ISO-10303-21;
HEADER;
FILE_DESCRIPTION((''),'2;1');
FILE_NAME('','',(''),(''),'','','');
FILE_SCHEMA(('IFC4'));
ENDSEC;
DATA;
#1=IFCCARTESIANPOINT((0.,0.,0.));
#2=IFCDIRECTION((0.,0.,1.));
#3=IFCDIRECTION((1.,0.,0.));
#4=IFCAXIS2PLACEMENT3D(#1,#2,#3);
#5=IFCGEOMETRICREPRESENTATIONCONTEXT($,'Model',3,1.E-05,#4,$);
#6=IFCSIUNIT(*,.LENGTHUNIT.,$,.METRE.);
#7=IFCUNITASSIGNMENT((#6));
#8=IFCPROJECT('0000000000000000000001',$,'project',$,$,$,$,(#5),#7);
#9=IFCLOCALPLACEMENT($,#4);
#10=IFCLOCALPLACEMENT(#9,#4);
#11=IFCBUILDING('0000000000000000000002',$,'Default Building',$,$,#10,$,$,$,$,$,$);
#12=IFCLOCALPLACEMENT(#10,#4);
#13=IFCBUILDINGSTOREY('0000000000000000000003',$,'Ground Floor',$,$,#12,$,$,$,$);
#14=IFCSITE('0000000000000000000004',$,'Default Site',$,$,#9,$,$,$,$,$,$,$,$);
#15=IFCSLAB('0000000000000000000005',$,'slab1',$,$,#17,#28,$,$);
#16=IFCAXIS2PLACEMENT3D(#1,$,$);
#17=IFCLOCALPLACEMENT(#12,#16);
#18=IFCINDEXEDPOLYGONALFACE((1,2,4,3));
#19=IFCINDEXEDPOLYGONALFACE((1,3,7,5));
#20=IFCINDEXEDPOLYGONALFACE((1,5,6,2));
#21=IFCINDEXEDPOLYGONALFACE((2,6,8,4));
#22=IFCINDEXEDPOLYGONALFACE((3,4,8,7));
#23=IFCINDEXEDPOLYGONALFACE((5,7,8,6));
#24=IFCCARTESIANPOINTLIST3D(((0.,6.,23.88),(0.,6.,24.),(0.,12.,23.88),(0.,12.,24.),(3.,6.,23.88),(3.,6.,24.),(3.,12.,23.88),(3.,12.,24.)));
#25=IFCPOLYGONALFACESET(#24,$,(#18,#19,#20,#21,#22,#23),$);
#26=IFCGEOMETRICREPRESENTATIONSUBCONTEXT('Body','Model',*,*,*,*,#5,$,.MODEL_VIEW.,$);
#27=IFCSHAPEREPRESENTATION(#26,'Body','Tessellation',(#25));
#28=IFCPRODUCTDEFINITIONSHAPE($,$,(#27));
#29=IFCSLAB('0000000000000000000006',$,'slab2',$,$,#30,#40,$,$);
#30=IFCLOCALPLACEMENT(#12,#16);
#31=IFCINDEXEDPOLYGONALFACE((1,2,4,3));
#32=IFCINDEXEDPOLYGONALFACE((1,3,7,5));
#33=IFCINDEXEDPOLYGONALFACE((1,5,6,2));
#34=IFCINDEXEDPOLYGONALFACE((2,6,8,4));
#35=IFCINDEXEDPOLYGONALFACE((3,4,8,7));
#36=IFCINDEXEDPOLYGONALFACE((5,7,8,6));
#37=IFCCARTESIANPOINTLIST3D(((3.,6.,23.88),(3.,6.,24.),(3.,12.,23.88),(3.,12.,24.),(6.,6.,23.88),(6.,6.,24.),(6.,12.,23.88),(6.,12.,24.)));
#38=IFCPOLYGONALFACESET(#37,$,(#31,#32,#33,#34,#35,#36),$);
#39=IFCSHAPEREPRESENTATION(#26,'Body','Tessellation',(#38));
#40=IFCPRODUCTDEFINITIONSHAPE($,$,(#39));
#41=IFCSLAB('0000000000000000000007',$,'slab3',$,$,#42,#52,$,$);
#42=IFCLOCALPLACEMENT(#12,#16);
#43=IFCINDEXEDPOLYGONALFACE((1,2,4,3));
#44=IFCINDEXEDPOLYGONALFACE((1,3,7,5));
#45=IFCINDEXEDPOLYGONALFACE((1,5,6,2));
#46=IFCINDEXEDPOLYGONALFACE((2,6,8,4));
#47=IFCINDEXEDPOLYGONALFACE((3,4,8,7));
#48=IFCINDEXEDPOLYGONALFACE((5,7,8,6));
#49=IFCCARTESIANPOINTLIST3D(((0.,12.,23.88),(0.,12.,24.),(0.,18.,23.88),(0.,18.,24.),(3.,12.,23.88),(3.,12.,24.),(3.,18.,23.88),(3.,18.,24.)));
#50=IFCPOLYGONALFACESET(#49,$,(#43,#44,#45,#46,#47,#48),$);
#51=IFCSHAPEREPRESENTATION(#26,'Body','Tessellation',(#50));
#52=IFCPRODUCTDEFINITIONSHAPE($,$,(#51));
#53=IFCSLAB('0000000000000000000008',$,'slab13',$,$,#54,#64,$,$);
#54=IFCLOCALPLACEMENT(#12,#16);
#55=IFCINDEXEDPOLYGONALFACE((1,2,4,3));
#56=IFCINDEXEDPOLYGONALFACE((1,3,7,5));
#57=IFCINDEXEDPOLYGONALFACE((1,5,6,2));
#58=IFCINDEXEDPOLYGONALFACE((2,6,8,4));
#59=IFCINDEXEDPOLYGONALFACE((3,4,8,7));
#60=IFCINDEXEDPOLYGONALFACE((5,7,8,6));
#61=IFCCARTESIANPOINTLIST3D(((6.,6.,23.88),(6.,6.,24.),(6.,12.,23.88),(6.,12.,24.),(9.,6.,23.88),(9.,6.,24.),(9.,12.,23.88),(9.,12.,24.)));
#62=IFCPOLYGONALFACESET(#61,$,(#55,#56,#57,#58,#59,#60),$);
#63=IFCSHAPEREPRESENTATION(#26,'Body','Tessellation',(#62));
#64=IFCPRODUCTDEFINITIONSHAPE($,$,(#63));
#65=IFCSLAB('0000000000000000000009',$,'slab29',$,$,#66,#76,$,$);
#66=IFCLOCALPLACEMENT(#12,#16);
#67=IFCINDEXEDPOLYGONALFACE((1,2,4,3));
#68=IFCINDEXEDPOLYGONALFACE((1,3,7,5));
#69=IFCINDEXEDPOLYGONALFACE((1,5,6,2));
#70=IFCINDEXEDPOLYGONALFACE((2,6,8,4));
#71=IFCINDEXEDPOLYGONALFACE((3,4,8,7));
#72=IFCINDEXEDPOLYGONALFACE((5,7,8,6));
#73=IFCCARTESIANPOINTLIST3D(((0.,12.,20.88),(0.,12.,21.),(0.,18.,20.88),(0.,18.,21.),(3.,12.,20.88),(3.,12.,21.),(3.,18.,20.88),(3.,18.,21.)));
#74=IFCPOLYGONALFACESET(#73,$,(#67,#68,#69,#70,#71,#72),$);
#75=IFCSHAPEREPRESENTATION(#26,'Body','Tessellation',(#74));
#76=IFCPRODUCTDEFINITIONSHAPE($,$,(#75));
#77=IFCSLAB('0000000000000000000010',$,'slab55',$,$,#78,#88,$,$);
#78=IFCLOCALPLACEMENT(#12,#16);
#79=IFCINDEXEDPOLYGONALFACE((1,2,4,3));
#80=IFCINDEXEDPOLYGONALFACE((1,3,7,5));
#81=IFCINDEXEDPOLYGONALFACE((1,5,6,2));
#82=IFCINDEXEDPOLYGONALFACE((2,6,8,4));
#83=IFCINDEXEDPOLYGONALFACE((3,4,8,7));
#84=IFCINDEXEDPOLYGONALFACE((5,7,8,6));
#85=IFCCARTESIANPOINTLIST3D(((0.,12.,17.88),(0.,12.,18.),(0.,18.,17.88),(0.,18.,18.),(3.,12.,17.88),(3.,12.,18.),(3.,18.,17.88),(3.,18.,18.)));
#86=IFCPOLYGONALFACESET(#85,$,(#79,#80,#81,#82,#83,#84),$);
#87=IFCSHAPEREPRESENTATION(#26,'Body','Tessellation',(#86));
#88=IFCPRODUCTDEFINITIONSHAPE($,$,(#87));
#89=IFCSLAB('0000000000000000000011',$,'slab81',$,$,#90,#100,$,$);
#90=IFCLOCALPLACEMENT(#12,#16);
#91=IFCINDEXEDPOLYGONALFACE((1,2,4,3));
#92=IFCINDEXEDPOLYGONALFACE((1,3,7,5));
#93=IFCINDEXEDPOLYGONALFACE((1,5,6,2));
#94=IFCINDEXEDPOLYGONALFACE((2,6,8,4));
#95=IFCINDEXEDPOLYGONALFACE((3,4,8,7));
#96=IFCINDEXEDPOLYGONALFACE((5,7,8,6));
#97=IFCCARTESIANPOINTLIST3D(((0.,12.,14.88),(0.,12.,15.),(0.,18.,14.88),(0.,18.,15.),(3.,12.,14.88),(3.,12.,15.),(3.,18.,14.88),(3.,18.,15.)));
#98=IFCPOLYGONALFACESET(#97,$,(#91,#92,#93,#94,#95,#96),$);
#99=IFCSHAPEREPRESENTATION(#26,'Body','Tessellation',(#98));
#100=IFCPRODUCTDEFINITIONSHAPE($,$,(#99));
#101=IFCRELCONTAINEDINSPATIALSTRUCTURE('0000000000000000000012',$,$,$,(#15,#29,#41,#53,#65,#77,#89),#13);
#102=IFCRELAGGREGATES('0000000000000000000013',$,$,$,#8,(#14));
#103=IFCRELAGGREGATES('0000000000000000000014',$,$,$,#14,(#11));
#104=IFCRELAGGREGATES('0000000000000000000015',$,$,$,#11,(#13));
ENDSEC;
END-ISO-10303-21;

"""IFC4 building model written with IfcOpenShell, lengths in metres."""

from ifc_helpers import new_model, si_unit, frame, origin_with_axes, place, context, subcontext, project, spatial, indexed_curve, outline, extrude, element, save


model = new_model("IFC4")

# Units and contexts
model_context = context("Model", 3, precision=1e-05, world=origin_with_axes())
body_context = subcontext(model_context, "Body", "Model", "MODEL_VIEW")
ifc_project = project(units=[si_unit("LENGTHUNIT", "METRE")], contexts=[model_context])

# Site, building, storey
site_placement = place(None, origin_with_axes())
site = spatial("IfcSite", under=ifc_project, at=site_placement, Name="Default Site")
building_placement = place(site_placement, origin_with_axes())
building = spatial("IfcBuilding", under=site, at=building_placement, Name="Default Building")
storey_placement = place(building_placement, origin_with_axes())
storey = spatial("IfcBuildingStorey", under=building, at=storey_placement, Name="Ground Floor")

# Slabs
for number, where, z_axis, x_axis, name in (
    (1, (0.0, 6.0, 23.88), (0.0, 0.0, 1.0), (1.0, 0.0, 0.0), "slab1"),
    (2, (3.0, 6.0, 23.88), (0.0, 0.0, 1.0), (1.0, 0.0, 0.0), "slab2"),
    (3, (0.0, 12.0, 23.88), (0.0, 0.0, 1.0), (1.0, 0.0, 0.0), "slab3"),
    (4, (6.0, 6.0, 23.88), (0.0, 0.0, 1.0), (1.0, 0.0, 0.0), "slab13"),
    (5, (0.0, 12.0, 20.88), (0.0, 0.0, 1.0), (1.0, 0.0, 0.0), "slab29"),
    (6, (0.0, 12.0, 17.88), (0.0, 0.0, 1.0), (1.0, 0.0, 0.0), "slab55"),
    (7, (0.0, 12.0, 14.88), (0.0, 0.0, 1.0), (1.0, 0.0, 0.0), "slab81"),
):
    element("IfcSlab", number, at=place(storey_placement, frame(where, z_axis=z_axis, x_axis=x_axis)), inside=storey, Name=name, context=body_context, shape_type="SweptSolid", body=[
        extrude(outline(indexed_curve([(0.0, 0.0), (0.0, 6.0), (3.0, 6.0), (3.0, 0.0), (0.0, 0.0)], self_intersect=False)), origin_with_axes(), (0.0, 0.0, 1.0), 0.12),
    ])

save(model, "model.ifc")
